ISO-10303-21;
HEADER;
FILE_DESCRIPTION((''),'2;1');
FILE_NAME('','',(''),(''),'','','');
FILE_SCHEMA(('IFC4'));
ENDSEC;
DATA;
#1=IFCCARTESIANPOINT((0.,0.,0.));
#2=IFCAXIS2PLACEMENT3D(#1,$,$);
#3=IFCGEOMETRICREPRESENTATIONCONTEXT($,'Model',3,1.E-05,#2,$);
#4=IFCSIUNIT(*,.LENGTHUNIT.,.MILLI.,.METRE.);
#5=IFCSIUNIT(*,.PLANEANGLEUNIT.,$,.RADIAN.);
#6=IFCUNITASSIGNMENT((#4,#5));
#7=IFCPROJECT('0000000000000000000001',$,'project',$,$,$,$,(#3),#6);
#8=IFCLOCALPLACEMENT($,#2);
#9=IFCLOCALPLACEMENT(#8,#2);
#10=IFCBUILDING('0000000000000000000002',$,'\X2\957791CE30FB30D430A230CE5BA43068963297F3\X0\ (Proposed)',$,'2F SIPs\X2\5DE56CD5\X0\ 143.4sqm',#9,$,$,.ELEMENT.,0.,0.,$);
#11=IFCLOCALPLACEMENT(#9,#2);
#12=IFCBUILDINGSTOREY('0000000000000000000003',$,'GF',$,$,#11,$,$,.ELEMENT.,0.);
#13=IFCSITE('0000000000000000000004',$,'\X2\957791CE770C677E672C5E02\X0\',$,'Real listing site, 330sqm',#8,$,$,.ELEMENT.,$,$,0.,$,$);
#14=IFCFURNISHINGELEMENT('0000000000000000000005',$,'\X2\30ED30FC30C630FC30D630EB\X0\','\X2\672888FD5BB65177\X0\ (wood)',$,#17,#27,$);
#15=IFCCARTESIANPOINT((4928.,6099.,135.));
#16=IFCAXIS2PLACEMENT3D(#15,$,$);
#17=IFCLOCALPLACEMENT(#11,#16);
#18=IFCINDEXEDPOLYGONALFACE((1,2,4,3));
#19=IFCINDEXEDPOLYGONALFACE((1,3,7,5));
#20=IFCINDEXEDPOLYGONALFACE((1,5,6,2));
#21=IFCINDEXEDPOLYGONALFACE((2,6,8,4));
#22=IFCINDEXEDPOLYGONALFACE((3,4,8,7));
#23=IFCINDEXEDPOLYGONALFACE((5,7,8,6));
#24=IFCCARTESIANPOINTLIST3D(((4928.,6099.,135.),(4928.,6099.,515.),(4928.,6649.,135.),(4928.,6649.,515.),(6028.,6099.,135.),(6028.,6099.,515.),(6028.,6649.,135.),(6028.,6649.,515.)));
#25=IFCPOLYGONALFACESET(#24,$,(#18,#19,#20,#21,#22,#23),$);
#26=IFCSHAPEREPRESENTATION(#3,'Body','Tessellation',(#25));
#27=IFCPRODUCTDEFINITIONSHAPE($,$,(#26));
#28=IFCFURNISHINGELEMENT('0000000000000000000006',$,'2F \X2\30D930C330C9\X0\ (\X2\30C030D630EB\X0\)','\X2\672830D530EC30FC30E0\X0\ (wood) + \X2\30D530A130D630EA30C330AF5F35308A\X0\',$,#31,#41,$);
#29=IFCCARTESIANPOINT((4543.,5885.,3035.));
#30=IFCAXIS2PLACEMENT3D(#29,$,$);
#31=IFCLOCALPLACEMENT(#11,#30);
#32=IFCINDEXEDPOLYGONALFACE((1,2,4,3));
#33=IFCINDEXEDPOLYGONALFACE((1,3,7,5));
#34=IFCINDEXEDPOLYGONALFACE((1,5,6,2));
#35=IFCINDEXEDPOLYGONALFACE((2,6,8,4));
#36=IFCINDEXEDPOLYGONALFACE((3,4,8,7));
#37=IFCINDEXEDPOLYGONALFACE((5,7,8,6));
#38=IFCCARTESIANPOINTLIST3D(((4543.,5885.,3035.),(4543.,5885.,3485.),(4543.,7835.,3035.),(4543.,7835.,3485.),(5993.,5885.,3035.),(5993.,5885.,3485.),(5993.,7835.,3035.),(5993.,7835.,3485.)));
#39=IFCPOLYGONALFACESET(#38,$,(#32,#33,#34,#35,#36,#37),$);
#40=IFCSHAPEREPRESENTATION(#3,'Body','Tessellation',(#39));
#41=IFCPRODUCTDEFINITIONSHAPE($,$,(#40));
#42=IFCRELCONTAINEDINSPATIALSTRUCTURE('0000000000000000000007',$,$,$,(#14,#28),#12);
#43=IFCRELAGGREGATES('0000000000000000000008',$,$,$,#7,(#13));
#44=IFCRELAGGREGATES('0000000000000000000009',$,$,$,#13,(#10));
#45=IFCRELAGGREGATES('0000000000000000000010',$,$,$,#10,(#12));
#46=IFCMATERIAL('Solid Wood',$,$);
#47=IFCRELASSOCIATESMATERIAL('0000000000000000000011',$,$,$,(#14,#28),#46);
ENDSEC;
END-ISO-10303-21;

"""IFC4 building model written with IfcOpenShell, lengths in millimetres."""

from ifc_helpers import new_model, si_unit, frame, frame_2d, origin, place, context, project, spatial, rectangle, extrude, material, element, save


model = new_model("IFC4")

# Units and contexts
model_context = context("Model", 3, precision=1e-05, world=origin())
ifc_project = project(units=[si_unit("LENGTHUNIT", "METRE", prefix="MILLI"), si_unit("PLANEANGLEUNIT", "RADIAN")], contexts=[model_context])

# Site, building, storey
site_placement = place(None, origin())
site = spatial("IfcSite", under=ifc_project, at=site_placement, Name="長野県松本市", ObjectType="Real listing site, 330sqm", CompositionType="ELEMENT", RefElevation=0.0)
building_placement = place(site_placement, origin())
building = spatial("IfcBuilding", under=site, at=building_placement, Name="長野・ピアノ室と防音 (Proposed)", ObjectType="2F SIPs工法 143.4sqm", CompositionType="ELEMENT", ElevationOfRefHeight=0.0, ElevationOfTerrain=0.0)
storey_placement = place(building_placement, origin())
storey = spatial("IfcBuildingStorey", under=building, at=storey_placement, Name="GF", CompositionType="ELEMENT", Elevation=0.0)

# Shared definitions
ifc_material_1 = material(Name="Solid Wood")

# Furnishing elements
furnishing_1_placement = place(storey_placement, frame((4928.0, 6099.0, 135.0)))
element("IfcFurnishingElement", 1, at=furnishing_1_placement, inside=storey, material=ifc_material_1, Name="ローテーブル", Description="木製家具 (wood)", context=model_context, shape_type="SweptSolid", body=[
    extrude(rectangle(XDim=1100.0, YDim=550.0, at=frame_2d((550.0, 275.0))), frame((4928.0, 6099.0, 135.0)), (0.0, 0.0, 1.0), 380.0),
])
furnishing_2_placement = place(storey_placement, frame((4543.0, 5885.0, 3035.0)))
element("IfcFurnishingElement", 2, at=furnishing_2_placement, inside=storey, material=ifc_material_1, Name="2F ベッド (ダブル)", Description="木フレーム (wood) + ファブリック張り", context=model_context, shape_type="SweptSolid", body=[
    extrude(rectangle(XDim=1450.0, YDim=1950.0, at=frame_2d((725.0, 975.0))), frame((4543.0, 5885.0, 3035.0)), (0.0, 0.0, 1.0), 450.0),
])

save(model, "model.ifc")
